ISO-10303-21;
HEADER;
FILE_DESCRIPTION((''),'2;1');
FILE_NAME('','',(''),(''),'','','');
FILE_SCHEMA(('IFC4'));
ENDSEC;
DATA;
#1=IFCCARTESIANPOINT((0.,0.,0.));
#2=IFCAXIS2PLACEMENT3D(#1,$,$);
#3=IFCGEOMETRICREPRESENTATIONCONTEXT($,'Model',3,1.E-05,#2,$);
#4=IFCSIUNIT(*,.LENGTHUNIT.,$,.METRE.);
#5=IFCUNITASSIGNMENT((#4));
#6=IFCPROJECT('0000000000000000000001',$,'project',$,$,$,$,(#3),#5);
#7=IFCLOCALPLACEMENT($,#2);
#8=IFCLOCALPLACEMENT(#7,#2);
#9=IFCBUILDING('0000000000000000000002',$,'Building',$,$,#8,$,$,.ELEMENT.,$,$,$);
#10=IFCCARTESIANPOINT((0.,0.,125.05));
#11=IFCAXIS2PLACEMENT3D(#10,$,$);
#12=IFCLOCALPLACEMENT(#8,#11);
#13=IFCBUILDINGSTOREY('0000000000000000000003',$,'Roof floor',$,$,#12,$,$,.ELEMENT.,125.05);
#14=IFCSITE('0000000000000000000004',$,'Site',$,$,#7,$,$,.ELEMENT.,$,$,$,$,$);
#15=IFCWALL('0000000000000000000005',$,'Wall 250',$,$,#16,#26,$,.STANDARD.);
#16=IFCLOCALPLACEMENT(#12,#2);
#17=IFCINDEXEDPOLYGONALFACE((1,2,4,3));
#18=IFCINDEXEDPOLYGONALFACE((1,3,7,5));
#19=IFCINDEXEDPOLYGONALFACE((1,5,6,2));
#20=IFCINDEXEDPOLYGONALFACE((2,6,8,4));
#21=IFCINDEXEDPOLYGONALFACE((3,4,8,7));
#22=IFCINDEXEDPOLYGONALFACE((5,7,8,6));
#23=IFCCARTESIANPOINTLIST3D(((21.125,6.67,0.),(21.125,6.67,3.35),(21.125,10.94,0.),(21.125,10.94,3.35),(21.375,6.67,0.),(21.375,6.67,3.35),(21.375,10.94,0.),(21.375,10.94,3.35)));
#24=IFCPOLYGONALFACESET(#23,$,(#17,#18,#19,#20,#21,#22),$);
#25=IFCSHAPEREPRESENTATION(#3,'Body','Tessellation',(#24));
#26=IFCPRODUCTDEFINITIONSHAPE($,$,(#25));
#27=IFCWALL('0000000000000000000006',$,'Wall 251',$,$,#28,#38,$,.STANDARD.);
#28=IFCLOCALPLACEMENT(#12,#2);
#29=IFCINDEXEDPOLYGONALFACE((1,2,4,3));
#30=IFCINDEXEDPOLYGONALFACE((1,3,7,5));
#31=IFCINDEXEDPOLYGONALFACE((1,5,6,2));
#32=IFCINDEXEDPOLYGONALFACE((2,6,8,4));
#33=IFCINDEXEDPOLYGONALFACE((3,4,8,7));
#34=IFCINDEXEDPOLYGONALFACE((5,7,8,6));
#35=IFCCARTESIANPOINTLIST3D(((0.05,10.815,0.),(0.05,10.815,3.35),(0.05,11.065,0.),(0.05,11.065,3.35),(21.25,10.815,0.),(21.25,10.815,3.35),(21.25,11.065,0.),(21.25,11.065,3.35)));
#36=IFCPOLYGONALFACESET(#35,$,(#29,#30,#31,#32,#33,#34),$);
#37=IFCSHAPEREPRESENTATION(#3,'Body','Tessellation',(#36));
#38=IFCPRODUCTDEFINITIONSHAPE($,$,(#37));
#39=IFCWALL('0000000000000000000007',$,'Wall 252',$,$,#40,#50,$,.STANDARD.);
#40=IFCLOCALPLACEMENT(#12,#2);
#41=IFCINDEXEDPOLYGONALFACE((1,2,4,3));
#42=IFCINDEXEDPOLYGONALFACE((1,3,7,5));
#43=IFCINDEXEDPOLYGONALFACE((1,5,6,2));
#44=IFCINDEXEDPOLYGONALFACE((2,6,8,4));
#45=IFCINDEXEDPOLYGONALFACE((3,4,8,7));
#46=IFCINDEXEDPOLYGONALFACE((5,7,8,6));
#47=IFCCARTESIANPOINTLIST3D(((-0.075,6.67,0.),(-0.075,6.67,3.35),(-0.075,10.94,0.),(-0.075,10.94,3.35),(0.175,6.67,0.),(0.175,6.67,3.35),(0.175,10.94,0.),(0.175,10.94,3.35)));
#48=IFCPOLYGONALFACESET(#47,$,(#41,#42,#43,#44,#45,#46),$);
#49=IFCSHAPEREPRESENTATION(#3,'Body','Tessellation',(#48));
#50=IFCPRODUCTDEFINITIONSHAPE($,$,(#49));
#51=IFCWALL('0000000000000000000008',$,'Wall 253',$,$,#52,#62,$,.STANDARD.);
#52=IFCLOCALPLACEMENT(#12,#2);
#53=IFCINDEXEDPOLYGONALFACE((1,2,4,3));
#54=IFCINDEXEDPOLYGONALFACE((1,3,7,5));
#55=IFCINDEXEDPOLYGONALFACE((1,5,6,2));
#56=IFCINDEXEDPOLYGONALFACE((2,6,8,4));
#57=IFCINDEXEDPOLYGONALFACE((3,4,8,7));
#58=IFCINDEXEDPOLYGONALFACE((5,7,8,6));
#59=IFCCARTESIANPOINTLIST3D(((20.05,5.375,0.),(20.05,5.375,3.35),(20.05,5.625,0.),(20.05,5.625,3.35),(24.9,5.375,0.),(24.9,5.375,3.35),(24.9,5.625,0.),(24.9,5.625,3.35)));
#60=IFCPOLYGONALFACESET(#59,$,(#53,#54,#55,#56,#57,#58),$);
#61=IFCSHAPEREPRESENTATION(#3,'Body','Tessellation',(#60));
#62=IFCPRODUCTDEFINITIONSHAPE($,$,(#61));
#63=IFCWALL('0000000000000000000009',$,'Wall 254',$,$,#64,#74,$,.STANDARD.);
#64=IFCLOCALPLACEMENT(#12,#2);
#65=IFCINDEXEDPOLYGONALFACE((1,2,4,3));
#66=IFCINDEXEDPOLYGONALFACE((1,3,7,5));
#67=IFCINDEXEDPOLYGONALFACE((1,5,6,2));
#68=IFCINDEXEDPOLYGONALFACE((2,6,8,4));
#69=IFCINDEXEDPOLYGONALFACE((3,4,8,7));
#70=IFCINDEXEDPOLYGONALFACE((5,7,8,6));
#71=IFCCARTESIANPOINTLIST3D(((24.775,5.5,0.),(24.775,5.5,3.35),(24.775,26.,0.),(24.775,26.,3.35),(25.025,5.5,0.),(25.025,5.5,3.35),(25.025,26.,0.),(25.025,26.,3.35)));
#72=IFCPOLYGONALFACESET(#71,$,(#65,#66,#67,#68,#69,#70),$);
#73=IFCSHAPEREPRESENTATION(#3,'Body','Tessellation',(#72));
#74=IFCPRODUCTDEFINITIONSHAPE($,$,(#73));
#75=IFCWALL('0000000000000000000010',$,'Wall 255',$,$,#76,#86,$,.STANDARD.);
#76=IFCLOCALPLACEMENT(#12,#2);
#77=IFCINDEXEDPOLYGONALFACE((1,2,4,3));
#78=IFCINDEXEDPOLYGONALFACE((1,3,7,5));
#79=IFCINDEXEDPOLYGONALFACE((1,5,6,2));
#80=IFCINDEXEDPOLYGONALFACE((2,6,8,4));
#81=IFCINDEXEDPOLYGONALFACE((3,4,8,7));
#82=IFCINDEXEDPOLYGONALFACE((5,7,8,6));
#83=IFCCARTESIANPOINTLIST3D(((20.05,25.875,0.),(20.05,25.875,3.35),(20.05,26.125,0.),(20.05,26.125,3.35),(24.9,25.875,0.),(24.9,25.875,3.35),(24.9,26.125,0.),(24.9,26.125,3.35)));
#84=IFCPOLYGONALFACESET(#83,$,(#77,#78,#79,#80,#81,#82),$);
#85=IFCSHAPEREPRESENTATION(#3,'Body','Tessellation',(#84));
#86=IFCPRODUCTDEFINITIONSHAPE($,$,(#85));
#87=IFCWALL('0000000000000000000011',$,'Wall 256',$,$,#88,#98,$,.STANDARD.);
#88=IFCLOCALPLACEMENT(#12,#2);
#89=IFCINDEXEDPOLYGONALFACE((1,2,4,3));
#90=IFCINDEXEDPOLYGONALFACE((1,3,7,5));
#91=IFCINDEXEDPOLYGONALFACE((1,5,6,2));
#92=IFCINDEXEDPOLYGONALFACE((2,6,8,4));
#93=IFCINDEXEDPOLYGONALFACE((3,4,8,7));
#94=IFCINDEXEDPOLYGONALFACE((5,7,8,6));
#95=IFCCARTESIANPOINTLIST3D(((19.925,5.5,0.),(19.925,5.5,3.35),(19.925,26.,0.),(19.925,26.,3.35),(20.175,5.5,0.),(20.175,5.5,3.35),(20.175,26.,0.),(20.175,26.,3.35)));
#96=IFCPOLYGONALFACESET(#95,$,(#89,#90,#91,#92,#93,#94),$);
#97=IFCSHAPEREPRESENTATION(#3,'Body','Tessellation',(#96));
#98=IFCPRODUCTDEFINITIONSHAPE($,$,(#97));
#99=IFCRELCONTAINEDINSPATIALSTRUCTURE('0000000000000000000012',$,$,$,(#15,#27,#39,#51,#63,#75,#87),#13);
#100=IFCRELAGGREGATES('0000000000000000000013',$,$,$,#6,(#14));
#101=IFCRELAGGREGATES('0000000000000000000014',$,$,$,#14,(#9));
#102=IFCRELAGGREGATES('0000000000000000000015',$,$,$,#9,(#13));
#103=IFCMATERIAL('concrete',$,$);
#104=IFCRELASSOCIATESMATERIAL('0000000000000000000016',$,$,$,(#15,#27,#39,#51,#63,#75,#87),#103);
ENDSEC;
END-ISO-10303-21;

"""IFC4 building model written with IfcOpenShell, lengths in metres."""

from ifc_helpers import new_model, si_unit, frame, frame_2d, origin, place, context, project, spatial, rectangle, extrude, material, element, save


model = new_model("IFC4")

# Units and contexts
model_context = context("Model", 3, precision=1e-05, world=origin())
ifc_project = project(units=[si_unit("LENGTHUNIT", "METRE")], contexts=[model_context])

# Site, building, storey
site_placement = place(None, origin())
site = spatial("IfcSite", under=ifc_project, at=site_placement, Name="Site", CompositionType="ELEMENT")
building_placement = place(site_placement, origin())
building = spatial("IfcBuilding", under=site, at=building_placement, Name="Building", CompositionType="ELEMENT")
storey_placement = place(building_placement, frame((0.0, 0.0, 125.05)))
storey = spatial("IfcBuildingStorey", under=building, at=storey_placement, Name="Roof floor", CompositionType="ELEMENT", Elevation=125.05)

# Shared definitions
ifc_material = material(Name="concrete")

# Walls
wall_1_placement = place(storey_placement, frame((21.25, 6.67, 0.0), z_axis=(0.0, 0.0, 1.0), x_axis=(0.0, 1.0, 0.0)))
element("IfcWall", 1, at=wall_1_placement, inside=storey, material=ifc_material, Name="Wall 250", PredefinedType="STANDARD", context=model_context, shape_type="SweptSolid", body=[
    extrude(rectangle(XDim=4.27, YDim=0.25, at=frame_2d((2.135, 0.0))), origin(), (0.0, 0.0, 1.0), 3.35),
])
wall_2_placement = place(storey_placement, frame((21.25, 10.94, 0.0), z_axis=(0.0, 0.0, 1.0), x_axis=(-1.0, 0.0, 0.0)))
element("IfcWall", 2, at=wall_2_placement, inside=storey, material=ifc_material, Name="Wall 251", PredefinedType="STANDARD", context=model_context, shape_type="SweptSolid", body=[
    extrude(rectangle(XDim=21.2, YDim=0.25, at=frame_2d((10.6, 0.0))), origin(), (0.0, 0.0, 1.0), 3.35),
])
wall_3_placement = place(storey_placement, frame((0.05, 10.94, 0.0), z_axis=(0.0, 0.0, 1.0), x_axis=(0.0, -1.0, 0.0)))
element("IfcWall", 3, at=wall_3_placement, inside=storey, material=ifc_material, Name="Wall 252", PredefinedType="STANDARD", context=model_context, shape_type="SweptSolid", body=[
    extrude(rectangle(XDim=4.27, YDim=0.25, at=frame_2d((2.135, 0.0))), origin(), (0.0, 0.0, 1.0), 3.35),
])
wall_4_placement = place(storey_placement, frame((20.05, 5.5, 0.0), z_axis=(0.0, 0.0, 1.0), x_axis=(1.0, 0.0, 0.0)))
element("IfcWall", 4, at=wall_4_placement, inside=storey, material=ifc_material, Name="Wall 253", PredefinedType="STANDARD", context=model_context, shape_type="SweptSolid", body=[
    extrude(rectangle(XDim=4.85, YDim=0.25, at=frame_2d((2.425, 0.0))), origin(), (0.0, 0.0, 1.0), 3.35),
])
wall_5_placement = place(storey_placement, frame((24.9, 5.5, 0.0), z_axis=(0.0, 0.0, 1.0), x_axis=(0.0, 1.0, 0.0)))
element("IfcWall", 5, at=wall_5_placement, inside=storey, material=ifc_material, Name="Wall 254", PredefinedType="STANDARD", context=model_context, shape_type="SweptSolid", body=[
    extrude(rectangle(XDim=20.5, YDim=0.25, at=frame_2d((10.25, 0.0))), origin(), (0.0, 0.0, 1.0), 3.35),
])
wall_6_placement = place(storey_placement, frame((24.9, 26.0, 0.0), z_axis=(0.0, 0.0, 1.0), x_axis=(-1.0, 0.0, 0.0)))
element("IfcWall", 6, at=wall_6_placement, inside=storey, material=ifc_material, Name="Wall 255", PredefinedType="STANDARD", context=model_context, shape_type="SweptSolid", body=[
    extrude(rectangle(XDim=4.85, YDim=0.25, at=frame_2d((2.425, 0.0))), origin(), (0.0, 0.0, 1.0), 3.35),
])
wall_7_placement = place(storey_placement, frame((20.05, 26.0, 0.0), z_axis=(0.0, 0.0, 1.0), x_axis=(0.0, -1.0, 0.0)))
element("IfcWall", 7, at=wall_7_placement, inside=storey, material=ifc_material, Name="Wall 256", PredefinedType="STANDARD", context=model_context, shape_type="SweptSolid", body=[
    extrude(rectangle(XDim=20.5, YDim=0.25, at=frame_2d((10.25, 0.0))), origin(), (0.0, 0.0, 1.0), 3.35),
])

save(model, "model.ifc")
